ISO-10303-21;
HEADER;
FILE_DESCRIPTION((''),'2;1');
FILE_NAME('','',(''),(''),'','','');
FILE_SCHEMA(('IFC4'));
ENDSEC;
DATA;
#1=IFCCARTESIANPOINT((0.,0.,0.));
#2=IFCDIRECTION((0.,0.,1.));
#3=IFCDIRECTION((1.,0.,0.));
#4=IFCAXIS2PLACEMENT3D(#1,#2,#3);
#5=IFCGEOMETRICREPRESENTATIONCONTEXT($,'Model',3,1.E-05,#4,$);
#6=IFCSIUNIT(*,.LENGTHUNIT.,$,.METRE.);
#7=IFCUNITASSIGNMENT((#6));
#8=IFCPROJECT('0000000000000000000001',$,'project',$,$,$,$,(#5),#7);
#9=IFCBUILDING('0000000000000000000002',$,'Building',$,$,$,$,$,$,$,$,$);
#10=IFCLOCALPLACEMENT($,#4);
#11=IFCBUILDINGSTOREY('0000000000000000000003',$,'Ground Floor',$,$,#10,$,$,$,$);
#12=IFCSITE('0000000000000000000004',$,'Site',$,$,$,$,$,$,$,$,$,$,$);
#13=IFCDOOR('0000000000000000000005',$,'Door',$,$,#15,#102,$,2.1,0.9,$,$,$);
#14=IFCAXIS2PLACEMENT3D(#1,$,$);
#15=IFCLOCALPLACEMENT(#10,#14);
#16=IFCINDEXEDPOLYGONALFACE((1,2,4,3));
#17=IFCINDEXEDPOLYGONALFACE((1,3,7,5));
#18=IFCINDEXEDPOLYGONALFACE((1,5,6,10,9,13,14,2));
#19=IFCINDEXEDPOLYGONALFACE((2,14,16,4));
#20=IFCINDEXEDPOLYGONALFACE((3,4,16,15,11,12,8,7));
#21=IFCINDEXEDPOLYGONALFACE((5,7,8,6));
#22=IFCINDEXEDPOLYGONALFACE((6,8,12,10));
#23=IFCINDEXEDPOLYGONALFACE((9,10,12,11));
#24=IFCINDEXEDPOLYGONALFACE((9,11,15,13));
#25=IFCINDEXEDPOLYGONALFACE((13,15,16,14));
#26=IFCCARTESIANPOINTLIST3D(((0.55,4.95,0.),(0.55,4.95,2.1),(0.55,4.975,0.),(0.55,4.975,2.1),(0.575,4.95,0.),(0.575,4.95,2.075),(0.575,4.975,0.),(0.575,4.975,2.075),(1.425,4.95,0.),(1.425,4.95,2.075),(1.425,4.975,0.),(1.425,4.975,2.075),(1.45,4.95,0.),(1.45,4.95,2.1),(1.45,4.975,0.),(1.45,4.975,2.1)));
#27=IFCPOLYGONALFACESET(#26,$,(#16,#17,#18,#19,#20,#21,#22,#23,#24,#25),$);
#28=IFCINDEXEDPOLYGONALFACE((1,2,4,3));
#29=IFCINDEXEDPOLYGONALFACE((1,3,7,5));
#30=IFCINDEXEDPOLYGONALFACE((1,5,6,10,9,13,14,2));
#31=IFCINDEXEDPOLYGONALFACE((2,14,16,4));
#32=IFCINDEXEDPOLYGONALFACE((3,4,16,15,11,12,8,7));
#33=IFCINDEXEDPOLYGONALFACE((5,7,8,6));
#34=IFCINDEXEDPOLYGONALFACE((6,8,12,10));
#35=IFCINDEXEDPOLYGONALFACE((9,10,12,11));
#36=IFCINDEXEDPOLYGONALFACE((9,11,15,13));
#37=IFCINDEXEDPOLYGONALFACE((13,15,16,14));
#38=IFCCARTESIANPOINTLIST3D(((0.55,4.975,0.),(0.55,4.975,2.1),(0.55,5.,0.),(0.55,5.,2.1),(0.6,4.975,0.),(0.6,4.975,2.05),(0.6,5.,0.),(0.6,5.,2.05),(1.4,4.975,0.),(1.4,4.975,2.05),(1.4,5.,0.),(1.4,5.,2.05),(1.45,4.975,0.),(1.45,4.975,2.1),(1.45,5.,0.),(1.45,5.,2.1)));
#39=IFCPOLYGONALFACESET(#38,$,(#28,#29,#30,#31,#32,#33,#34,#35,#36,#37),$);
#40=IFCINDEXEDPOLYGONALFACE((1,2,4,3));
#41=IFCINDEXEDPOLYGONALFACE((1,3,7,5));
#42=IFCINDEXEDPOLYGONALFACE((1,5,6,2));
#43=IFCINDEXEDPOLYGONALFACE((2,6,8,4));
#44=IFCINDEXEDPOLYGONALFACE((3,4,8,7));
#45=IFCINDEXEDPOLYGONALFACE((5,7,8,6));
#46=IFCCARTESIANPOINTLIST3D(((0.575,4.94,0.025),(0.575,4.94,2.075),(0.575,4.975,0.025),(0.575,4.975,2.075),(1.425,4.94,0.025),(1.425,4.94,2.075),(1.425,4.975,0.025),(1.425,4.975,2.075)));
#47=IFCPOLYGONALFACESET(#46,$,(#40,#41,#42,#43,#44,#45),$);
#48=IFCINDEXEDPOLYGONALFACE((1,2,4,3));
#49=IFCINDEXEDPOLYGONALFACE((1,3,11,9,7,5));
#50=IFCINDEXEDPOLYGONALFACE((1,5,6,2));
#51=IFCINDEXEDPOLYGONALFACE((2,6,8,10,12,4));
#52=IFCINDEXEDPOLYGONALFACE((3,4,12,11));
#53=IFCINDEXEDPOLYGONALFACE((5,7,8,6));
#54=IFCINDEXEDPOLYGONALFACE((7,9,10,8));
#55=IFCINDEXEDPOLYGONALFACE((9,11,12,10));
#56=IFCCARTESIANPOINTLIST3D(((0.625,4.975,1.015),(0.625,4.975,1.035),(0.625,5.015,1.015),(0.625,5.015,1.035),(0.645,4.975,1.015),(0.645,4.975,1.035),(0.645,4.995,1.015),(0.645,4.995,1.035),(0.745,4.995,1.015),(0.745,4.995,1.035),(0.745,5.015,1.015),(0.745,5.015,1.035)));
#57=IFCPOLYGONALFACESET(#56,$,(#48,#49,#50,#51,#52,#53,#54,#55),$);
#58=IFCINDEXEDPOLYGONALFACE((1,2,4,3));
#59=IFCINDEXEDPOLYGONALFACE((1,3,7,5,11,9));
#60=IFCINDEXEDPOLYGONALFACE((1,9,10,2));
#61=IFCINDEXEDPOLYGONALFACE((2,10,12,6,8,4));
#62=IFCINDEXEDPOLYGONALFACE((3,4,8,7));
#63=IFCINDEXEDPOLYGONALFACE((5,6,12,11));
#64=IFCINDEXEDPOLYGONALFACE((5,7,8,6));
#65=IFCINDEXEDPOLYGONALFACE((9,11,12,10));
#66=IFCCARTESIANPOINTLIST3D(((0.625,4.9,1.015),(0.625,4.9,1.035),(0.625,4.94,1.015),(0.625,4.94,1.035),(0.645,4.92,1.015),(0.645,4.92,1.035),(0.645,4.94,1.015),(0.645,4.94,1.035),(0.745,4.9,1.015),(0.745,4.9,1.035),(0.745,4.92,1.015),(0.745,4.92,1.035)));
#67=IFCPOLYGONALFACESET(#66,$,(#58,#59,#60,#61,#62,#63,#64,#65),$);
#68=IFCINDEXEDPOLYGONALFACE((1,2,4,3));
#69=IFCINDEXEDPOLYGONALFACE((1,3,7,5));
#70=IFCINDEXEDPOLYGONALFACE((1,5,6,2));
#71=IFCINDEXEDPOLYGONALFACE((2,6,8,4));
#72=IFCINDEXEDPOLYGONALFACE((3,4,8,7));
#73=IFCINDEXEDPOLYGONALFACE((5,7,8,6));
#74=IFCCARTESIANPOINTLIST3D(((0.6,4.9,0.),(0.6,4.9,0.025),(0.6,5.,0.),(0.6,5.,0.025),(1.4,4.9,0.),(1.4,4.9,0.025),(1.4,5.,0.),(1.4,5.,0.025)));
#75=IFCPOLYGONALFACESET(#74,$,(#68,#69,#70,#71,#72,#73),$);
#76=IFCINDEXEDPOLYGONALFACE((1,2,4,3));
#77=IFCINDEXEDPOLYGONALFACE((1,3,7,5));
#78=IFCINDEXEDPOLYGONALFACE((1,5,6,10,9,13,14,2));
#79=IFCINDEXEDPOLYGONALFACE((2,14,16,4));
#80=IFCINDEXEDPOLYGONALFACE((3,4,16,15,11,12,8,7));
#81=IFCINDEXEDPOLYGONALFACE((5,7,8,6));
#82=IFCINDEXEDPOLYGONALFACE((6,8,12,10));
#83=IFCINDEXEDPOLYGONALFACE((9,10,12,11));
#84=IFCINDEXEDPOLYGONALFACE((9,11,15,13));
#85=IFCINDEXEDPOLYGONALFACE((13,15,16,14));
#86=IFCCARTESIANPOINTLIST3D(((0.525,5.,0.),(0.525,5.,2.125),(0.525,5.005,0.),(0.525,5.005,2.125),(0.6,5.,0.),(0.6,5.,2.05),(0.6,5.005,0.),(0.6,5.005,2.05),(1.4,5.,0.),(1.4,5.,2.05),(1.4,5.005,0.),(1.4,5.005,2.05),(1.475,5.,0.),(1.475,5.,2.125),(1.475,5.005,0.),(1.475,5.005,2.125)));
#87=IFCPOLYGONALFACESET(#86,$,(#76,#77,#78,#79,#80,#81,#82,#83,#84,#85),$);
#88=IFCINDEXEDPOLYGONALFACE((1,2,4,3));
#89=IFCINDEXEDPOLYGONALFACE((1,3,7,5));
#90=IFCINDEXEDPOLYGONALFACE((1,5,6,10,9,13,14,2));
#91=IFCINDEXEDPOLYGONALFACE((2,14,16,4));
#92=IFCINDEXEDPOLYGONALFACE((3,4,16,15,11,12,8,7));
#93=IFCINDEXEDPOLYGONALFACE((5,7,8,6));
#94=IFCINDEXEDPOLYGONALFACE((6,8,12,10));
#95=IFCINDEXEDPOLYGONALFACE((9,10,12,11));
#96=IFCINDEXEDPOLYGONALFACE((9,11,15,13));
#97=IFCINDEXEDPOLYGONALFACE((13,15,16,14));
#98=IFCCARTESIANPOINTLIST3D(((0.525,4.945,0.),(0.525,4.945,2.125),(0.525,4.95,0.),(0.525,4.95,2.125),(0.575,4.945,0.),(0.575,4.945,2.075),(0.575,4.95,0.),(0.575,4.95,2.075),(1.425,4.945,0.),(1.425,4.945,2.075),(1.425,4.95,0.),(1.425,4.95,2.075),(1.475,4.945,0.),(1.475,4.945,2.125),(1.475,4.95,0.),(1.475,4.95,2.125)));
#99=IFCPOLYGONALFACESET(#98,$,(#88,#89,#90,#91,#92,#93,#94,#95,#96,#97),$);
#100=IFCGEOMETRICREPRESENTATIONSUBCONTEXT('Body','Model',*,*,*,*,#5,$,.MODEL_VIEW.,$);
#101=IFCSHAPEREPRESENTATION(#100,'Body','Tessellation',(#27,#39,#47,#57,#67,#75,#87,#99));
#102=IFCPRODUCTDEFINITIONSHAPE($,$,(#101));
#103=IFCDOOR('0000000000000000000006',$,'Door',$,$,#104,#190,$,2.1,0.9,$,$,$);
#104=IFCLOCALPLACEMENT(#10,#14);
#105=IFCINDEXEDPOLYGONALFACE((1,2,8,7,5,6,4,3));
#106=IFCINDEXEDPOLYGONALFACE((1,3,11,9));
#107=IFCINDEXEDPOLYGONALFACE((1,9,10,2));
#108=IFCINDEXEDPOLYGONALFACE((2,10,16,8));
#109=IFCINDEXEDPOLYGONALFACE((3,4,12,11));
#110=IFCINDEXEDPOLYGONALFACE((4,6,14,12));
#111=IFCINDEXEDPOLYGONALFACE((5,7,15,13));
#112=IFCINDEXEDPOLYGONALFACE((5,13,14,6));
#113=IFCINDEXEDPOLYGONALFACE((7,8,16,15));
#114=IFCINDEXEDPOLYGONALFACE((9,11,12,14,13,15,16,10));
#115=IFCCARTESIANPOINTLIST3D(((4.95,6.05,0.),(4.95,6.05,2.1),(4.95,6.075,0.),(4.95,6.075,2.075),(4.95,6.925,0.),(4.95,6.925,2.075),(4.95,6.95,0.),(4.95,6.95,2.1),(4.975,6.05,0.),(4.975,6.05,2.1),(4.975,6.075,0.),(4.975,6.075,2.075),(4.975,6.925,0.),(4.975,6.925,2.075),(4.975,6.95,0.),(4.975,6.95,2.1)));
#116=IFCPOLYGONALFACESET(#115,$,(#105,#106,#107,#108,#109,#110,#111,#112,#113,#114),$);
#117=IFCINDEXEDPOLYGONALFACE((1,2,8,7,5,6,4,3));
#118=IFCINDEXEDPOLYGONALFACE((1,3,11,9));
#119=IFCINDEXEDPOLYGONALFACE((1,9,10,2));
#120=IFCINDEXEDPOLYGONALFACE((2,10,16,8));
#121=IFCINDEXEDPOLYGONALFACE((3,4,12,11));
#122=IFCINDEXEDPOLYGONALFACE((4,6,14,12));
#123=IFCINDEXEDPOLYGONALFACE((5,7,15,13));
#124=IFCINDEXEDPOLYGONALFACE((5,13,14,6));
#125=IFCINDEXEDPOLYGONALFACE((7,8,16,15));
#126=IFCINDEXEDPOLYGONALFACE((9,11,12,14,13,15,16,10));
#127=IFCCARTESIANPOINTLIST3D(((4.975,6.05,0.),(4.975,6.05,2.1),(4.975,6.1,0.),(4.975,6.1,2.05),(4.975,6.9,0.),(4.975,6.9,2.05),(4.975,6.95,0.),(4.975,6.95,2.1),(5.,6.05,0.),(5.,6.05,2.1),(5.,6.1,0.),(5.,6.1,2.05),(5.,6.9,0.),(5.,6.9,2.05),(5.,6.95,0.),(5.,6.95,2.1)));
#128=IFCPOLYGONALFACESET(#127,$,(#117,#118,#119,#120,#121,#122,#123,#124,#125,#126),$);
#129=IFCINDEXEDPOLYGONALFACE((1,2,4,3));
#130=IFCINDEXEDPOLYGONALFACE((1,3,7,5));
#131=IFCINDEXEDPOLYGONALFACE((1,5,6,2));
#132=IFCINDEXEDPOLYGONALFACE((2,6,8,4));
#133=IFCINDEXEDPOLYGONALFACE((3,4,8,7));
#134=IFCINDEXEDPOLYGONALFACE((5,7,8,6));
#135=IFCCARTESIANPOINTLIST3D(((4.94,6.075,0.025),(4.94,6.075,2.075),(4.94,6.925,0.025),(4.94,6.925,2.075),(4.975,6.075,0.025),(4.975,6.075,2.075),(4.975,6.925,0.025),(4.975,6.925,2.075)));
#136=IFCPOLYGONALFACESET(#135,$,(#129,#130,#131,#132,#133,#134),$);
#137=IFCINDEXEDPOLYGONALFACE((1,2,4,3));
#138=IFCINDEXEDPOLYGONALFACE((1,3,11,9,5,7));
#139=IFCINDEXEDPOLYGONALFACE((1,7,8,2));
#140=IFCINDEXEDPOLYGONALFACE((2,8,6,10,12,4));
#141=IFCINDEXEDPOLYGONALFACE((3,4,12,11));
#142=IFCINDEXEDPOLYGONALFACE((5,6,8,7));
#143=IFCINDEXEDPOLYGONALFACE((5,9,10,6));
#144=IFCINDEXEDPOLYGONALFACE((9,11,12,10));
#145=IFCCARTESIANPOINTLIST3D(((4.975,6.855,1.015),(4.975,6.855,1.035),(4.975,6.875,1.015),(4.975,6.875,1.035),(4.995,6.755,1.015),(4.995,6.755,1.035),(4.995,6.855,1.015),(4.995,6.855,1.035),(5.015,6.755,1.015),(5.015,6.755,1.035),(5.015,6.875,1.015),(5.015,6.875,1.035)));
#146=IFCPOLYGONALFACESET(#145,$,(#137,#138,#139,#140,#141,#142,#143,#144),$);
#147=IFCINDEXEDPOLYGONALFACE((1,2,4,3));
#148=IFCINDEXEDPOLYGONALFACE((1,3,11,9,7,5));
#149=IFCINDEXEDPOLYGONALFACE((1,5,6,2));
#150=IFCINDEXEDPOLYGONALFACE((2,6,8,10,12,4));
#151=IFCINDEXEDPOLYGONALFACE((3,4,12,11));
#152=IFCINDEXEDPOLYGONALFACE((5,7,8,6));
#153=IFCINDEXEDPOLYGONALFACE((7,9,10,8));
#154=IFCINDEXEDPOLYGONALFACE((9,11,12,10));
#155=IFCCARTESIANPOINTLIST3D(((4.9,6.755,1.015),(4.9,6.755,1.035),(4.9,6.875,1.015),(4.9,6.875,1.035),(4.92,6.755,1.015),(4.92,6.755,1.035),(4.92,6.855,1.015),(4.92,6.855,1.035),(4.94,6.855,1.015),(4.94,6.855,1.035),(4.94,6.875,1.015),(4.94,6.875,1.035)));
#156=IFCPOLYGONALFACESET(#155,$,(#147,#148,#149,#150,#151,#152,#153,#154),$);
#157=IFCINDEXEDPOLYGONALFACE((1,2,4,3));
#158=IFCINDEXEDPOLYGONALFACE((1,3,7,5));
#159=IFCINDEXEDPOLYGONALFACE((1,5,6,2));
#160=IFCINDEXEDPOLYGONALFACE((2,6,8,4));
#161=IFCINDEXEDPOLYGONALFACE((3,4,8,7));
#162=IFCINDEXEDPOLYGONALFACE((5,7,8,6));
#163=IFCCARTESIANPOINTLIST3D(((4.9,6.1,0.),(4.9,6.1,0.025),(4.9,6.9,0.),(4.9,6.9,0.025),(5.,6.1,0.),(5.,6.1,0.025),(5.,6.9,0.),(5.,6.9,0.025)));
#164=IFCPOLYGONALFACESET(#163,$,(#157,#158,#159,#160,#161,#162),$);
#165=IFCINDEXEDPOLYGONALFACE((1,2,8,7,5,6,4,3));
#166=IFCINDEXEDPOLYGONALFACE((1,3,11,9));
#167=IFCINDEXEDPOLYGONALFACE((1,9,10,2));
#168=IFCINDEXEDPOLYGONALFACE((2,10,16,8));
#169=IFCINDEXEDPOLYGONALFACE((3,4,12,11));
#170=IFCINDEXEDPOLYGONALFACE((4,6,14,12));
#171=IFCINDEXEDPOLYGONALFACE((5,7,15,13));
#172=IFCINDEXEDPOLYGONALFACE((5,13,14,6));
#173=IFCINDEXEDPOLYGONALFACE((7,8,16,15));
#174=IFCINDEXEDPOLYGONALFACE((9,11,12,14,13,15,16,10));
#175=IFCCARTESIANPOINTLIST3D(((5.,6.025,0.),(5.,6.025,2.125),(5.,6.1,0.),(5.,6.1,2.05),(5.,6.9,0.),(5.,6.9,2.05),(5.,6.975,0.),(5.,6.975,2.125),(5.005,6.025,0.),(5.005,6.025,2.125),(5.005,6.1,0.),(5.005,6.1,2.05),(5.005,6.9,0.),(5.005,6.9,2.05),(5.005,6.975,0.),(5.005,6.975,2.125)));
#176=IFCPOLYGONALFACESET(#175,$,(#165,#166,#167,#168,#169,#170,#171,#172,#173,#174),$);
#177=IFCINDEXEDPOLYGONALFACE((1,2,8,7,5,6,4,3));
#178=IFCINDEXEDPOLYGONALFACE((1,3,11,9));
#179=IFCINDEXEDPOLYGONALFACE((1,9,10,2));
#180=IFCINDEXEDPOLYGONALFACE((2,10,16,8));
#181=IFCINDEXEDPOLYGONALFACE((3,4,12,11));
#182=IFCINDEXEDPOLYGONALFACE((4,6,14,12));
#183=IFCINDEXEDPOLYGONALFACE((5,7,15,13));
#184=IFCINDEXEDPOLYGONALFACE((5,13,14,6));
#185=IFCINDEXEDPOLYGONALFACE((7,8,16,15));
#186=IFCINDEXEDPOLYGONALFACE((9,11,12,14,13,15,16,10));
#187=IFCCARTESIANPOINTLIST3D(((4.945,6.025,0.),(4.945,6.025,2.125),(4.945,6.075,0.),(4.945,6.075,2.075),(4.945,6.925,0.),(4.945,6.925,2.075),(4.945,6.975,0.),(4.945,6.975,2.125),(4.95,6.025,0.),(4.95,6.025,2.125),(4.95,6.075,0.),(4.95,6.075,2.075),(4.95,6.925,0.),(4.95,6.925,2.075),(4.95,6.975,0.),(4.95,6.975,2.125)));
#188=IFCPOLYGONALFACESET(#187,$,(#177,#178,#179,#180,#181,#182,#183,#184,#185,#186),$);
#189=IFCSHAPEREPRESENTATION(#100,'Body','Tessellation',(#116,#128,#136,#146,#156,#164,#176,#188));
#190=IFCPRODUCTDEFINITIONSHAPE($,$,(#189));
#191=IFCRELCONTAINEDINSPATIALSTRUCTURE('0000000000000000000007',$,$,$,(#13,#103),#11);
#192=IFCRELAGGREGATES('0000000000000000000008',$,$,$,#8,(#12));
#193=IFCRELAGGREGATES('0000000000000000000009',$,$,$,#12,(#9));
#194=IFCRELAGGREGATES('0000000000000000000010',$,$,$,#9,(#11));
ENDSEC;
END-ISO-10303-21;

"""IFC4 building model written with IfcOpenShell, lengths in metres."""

from ifc_helpers import new_model, si_unit, frame, origin_with_axes, place, context, subcontext, project, spatial, line, indexed_curve, outline, extrude, element, save


model = new_model("IFC4")

# Units and contexts
model_context = context("Model", 3, precision=1e-05, world=origin_with_axes())
body_context = subcontext(model_context, "Body", "Model", "MODEL_VIEW")
ifc_project = project(units=[si_unit("LENGTHUNIT", "METRE")], contexts=[model_context])

# Site, building, storey
site = spatial("IfcSite", under=ifc_project, Name="Site")
building = spatial("IfcBuilding", under=site, Name="Building")
storey_placement = place(None, origin_with_axes())
storey = spatial("IfcBuildingStorey", under=building, at=storey_placement, Name="Ground Floor")

# Doors
door_1_placement = place(storey_placement, frame((1.45, 5.0, 0.0), z_axis=(0.0, 0.0, 1.0), x_axis=(-1.0, 0.0, 0.0)))
element("IfcDoor", 1, at=door_1_placement, inside=storey, Name="Door", OverallHeight=2.1, OverallWidth=0.9, context=body_context, shape_type="SweptSolid", body=[
    extrude(outline(indexed_curve([(0.0, 0.0), (0.0, 2.1), (0.9, 2.1), (0.9, 0.0), (0.875, 0.0), (0.875, 2.075), (0.025, 2.075), (0.025, 0.0)], segments=[line(1, 2, 3, 4, 5, 6, 7, 8, 1)])), frame((0.0, 0.025, 0.0), z_axis=(0.0, -1.0, 0.0), x_axis=(1.0, 0.0, 0.0)), (0.0, 0.0, -1.0), 0.025),
    extrude(outline(indexed_curve([(0.0, 0.0), (0.0, 2.1), (0.9, 2.1), (0.9, 0.0), (0.85, 0.0), (0.85, 2.05), (0.05, 2.05), (0.05, 0.0)], segments=[line(1, 2, 3, 4, 5, 6, 7, 8, 1)])), frame((0.0, 0.0, 0.0), z_axis=(0.0, -1.0, 0.0), x_axis=(1.0, 0.0, 0.0)), (0.0, 0.0, -1.0), 0.025),
    extrude(outline(indexed_curve([(0.0, 0.0), (0.85, 0.0), (0.85, 0.035), (0.0, 0.035)], segments=[line(1, 2, 3, 4, 1)])), frame((0.025, 0.025, 0.025), z_axis=(0.0, 0.0, 1.0), x_axis=(1.0, 0.0, 0.0)), (0.0, 0.0, 1.0), 2.05),
    extrude(outline(indexed_curve([(0.0, 0.0), (0.0, -0.04), (-0.12, -0.04), (-0.12, -0.02), (-0.02, -0.02), (-0.02, 0.0)], segments=[line(1, 2, 3, 4, 5, 6, 1)])), frame((0.825, 0.025, 1.015), z_axis=(0.0, 0.0, 1.0), x_axis=(1.0, 0.0, 0.0)), (0.0, 0.0, 1.0), 0.02),
    extrude(outline(indexed_curve([(0.0, 0.0), (0.0, 0.04), (-0.12, 0.04), (-0.12, 0.02), (-0.02, 0.02), (-0.02, 0.0)], segments=[line(1, 2, 3, 4, 5, 6, 1)])), frame((0.825, 0.06, 1.015), z_axis=(0.0, 0.0, 1.0), x_axis=(1.0, 0.0, 0.0)), (0.0, 0.0, 1.0), 0.02),
    extrude(outline(indexed_curve([(0.0, 0.0), (0.8, 0.0), (0.8, 0.1), (0.0, 0.1)], segments=[line(1, 2, 3, 4, 1)])), frame((0.05, 0.0, 0.0), z_axis=(0.0, 0.0, 1.0), x_axis=(1.0, 0.0, 0.0)), (0.0, 0.0, 1.0), 0.025),
    extrude(outline(indexed_curve([(0.0, 0.0), (0.0, 2.125), (0.95, 2.125), (0.95, 0.0), (0.875, 0.0), (0.875, 2.05), (0.075, 2.05), (0.075, 0.0)], segments=[line(1, 2, 3, 4, 5, 6, 7, 8, 1)])), frame((-0.025, -0.005, 0.0), z_axis=(0.0, -1.0, 0.0), x_axis=(1.0, 0.0, 0.0)), (0.0, 0.0, -1.0), 0.005),
    extrude(outline(indexed_curve([(0.0, 0.0), (0.0, 2.125), (0.95, 2.125), (0.95, 0.0), (0.9, 0.0), (0.9, 2.075), (0.05, 2.075), (0.05, 0.0)], segments=[line(1, 2, 3, 4, 5, 6, 7, 8, 1)])), frame((-0.025, 0.05, 0.0), z_axis=(0.0, -1.0, 0.0), x_axis=(1.0, 0.0, 0.0)), (0.0, 0.0, -1.0), 0.005),
])
door_2_placement = place(storey_placement, frame((5.0, 6.05, 0.0), z_axis=(0.0, 0.0, 1.0), x_axis=(0.0, 1.0, 0.0)))
element("IfcDoor", 2, at=door_2_placement, inside=storey, Name="Door", OverallHeight=2.1, OverallWidth=0.9, context=body_context, shape_type="SweptSolid", body=[
    extrude(outline(indexed_curve([(0.0, 0.0), (0.0, 2.1), (0.9, 2.1), (0.9, 0.0), (0.875, 0.0), (0.875, 2.075), (0.025, 2.075), (0.025, 0.0)], segments=[line(1, 2, 3, 4, 5, 6, 7, 8, 1)])), frame((0.0, 0.025, 0.0), z_axis=(0.0, -1.0, 0.0), x_axis=(1.0, 0.0, 0.0)), (0.0, 0.0, -1.0), 0.025),
    extrude(outline(indexed_curve([(0.0, 0.0), (0.0, 2.1), (0.9, 2.1), (0.9, 0.0), (0.85, 0.0), (0.85, 2.05), (0.05, 2.05), (0.05, 0.0)], segments=[line(1, 2, 3, 4, 5, 6, 7, 8, 1)])), frame((0.0, 0.0, 0.0), z_axis=(0.0, -1.0, 0.0), x_axis=(1.0, 0.0, 0.0)), (0.0, 0.0, -1.0), 0.025),
    extrude(outline(indexed_curve([(0.0, 0.0), (0.85, 0.0), (0.85, 0.035), (0.0, 0.035)], segments=[line(1, 2, 3, 4, 1)])), frame((0.025, 0.025, 0.025), z_axis=(0.0, 0.0, 1.0), x_axis=(1.0, 0.0, 0.0)), (0.0, 0.0, 1.0), 2.05),
    extrude(outline(indexed_curve([(0.0, 0.0), (0.0, -0.04), (-0.12, -0.04), (-0.12, -0.02), (-0.02, -0.02), (-0.02, 0.0)], segments=[line(1, 2, 3, 4, 5, 6, 1)])), frame((0.825, 0.025, 1.015), z_axis=(0.0, 0.0, 1.0), x_axis=(1.0, 0.0, 0.0)), (0.0, 0.0, 1.0), 0.02),
    extrude(outline(indexed_curve([(0.0, 0.0), (0.0, 0.04), (-0.12, 0.04), (-0.12, 0.02), (-0.02, 0.02), (-0.02, 0.0)], segments=[line(1, 2, 3, 4, 5, 6, 1)])), frame((0.825, 0.06, 1.015), z_axis=(0.0, 0.0, 1.0), x_axis=(1.0, 0.0, 0.0)), (0.0, 0.0, 1.0), 0.02),
    extrude(outline(indexed_curve([(0.0, 0.0), (0.8, 0.0), (0.8, 0.1), (0.0, 0.1)], segments=[line(1, 2, 3, 4, 1)])), frame((0.05, 0.0, 0.0), z_axis=(0.0, 0.0, 1.0), x_axis=(1.0, 0.0, 0.0)), (0.0, 0.0, 1.0), 0.025),
    extrude(outline(indexed_curve([(0.0, 0.0), (0.0, 2.125), (0.95, 2.125), (0.95, 0.0), (0.875, 0.0), (0.875, 2.05), (0.075, 2.05), (0.075, 0.0)], segments=[line(1, 2, 3, 4, 5, 6, 7, 8, 1)])), frame((-0.025, -0.005, 0.0), z_axis=(0.0, -1.0, 0.0), x_axis=(1.0, 0.0, 0.0)), (0.0, 0.0, -1.0), 0.005),
    extrude(outline(indexed_curve([(0.0, 0.0), (0.0, 2.125), (0.95, 2.125), (0.95, 0.0), (0.9, 0.0), (0.9, 2.075), (0.05, 2.075), (0.05, 0.0)], segments=[line(1, 2, 3, 4, 5, 6, 7, 8, 1)])), frame((-0.025, 0.05, 0.0), z_axis=(0.0, -1.0, 0.0), x_axis=(1.0, 0.0, 0.0)), (0.0, 0.0, -1.0), 0.005),
])

save(model, "model.ifc")
